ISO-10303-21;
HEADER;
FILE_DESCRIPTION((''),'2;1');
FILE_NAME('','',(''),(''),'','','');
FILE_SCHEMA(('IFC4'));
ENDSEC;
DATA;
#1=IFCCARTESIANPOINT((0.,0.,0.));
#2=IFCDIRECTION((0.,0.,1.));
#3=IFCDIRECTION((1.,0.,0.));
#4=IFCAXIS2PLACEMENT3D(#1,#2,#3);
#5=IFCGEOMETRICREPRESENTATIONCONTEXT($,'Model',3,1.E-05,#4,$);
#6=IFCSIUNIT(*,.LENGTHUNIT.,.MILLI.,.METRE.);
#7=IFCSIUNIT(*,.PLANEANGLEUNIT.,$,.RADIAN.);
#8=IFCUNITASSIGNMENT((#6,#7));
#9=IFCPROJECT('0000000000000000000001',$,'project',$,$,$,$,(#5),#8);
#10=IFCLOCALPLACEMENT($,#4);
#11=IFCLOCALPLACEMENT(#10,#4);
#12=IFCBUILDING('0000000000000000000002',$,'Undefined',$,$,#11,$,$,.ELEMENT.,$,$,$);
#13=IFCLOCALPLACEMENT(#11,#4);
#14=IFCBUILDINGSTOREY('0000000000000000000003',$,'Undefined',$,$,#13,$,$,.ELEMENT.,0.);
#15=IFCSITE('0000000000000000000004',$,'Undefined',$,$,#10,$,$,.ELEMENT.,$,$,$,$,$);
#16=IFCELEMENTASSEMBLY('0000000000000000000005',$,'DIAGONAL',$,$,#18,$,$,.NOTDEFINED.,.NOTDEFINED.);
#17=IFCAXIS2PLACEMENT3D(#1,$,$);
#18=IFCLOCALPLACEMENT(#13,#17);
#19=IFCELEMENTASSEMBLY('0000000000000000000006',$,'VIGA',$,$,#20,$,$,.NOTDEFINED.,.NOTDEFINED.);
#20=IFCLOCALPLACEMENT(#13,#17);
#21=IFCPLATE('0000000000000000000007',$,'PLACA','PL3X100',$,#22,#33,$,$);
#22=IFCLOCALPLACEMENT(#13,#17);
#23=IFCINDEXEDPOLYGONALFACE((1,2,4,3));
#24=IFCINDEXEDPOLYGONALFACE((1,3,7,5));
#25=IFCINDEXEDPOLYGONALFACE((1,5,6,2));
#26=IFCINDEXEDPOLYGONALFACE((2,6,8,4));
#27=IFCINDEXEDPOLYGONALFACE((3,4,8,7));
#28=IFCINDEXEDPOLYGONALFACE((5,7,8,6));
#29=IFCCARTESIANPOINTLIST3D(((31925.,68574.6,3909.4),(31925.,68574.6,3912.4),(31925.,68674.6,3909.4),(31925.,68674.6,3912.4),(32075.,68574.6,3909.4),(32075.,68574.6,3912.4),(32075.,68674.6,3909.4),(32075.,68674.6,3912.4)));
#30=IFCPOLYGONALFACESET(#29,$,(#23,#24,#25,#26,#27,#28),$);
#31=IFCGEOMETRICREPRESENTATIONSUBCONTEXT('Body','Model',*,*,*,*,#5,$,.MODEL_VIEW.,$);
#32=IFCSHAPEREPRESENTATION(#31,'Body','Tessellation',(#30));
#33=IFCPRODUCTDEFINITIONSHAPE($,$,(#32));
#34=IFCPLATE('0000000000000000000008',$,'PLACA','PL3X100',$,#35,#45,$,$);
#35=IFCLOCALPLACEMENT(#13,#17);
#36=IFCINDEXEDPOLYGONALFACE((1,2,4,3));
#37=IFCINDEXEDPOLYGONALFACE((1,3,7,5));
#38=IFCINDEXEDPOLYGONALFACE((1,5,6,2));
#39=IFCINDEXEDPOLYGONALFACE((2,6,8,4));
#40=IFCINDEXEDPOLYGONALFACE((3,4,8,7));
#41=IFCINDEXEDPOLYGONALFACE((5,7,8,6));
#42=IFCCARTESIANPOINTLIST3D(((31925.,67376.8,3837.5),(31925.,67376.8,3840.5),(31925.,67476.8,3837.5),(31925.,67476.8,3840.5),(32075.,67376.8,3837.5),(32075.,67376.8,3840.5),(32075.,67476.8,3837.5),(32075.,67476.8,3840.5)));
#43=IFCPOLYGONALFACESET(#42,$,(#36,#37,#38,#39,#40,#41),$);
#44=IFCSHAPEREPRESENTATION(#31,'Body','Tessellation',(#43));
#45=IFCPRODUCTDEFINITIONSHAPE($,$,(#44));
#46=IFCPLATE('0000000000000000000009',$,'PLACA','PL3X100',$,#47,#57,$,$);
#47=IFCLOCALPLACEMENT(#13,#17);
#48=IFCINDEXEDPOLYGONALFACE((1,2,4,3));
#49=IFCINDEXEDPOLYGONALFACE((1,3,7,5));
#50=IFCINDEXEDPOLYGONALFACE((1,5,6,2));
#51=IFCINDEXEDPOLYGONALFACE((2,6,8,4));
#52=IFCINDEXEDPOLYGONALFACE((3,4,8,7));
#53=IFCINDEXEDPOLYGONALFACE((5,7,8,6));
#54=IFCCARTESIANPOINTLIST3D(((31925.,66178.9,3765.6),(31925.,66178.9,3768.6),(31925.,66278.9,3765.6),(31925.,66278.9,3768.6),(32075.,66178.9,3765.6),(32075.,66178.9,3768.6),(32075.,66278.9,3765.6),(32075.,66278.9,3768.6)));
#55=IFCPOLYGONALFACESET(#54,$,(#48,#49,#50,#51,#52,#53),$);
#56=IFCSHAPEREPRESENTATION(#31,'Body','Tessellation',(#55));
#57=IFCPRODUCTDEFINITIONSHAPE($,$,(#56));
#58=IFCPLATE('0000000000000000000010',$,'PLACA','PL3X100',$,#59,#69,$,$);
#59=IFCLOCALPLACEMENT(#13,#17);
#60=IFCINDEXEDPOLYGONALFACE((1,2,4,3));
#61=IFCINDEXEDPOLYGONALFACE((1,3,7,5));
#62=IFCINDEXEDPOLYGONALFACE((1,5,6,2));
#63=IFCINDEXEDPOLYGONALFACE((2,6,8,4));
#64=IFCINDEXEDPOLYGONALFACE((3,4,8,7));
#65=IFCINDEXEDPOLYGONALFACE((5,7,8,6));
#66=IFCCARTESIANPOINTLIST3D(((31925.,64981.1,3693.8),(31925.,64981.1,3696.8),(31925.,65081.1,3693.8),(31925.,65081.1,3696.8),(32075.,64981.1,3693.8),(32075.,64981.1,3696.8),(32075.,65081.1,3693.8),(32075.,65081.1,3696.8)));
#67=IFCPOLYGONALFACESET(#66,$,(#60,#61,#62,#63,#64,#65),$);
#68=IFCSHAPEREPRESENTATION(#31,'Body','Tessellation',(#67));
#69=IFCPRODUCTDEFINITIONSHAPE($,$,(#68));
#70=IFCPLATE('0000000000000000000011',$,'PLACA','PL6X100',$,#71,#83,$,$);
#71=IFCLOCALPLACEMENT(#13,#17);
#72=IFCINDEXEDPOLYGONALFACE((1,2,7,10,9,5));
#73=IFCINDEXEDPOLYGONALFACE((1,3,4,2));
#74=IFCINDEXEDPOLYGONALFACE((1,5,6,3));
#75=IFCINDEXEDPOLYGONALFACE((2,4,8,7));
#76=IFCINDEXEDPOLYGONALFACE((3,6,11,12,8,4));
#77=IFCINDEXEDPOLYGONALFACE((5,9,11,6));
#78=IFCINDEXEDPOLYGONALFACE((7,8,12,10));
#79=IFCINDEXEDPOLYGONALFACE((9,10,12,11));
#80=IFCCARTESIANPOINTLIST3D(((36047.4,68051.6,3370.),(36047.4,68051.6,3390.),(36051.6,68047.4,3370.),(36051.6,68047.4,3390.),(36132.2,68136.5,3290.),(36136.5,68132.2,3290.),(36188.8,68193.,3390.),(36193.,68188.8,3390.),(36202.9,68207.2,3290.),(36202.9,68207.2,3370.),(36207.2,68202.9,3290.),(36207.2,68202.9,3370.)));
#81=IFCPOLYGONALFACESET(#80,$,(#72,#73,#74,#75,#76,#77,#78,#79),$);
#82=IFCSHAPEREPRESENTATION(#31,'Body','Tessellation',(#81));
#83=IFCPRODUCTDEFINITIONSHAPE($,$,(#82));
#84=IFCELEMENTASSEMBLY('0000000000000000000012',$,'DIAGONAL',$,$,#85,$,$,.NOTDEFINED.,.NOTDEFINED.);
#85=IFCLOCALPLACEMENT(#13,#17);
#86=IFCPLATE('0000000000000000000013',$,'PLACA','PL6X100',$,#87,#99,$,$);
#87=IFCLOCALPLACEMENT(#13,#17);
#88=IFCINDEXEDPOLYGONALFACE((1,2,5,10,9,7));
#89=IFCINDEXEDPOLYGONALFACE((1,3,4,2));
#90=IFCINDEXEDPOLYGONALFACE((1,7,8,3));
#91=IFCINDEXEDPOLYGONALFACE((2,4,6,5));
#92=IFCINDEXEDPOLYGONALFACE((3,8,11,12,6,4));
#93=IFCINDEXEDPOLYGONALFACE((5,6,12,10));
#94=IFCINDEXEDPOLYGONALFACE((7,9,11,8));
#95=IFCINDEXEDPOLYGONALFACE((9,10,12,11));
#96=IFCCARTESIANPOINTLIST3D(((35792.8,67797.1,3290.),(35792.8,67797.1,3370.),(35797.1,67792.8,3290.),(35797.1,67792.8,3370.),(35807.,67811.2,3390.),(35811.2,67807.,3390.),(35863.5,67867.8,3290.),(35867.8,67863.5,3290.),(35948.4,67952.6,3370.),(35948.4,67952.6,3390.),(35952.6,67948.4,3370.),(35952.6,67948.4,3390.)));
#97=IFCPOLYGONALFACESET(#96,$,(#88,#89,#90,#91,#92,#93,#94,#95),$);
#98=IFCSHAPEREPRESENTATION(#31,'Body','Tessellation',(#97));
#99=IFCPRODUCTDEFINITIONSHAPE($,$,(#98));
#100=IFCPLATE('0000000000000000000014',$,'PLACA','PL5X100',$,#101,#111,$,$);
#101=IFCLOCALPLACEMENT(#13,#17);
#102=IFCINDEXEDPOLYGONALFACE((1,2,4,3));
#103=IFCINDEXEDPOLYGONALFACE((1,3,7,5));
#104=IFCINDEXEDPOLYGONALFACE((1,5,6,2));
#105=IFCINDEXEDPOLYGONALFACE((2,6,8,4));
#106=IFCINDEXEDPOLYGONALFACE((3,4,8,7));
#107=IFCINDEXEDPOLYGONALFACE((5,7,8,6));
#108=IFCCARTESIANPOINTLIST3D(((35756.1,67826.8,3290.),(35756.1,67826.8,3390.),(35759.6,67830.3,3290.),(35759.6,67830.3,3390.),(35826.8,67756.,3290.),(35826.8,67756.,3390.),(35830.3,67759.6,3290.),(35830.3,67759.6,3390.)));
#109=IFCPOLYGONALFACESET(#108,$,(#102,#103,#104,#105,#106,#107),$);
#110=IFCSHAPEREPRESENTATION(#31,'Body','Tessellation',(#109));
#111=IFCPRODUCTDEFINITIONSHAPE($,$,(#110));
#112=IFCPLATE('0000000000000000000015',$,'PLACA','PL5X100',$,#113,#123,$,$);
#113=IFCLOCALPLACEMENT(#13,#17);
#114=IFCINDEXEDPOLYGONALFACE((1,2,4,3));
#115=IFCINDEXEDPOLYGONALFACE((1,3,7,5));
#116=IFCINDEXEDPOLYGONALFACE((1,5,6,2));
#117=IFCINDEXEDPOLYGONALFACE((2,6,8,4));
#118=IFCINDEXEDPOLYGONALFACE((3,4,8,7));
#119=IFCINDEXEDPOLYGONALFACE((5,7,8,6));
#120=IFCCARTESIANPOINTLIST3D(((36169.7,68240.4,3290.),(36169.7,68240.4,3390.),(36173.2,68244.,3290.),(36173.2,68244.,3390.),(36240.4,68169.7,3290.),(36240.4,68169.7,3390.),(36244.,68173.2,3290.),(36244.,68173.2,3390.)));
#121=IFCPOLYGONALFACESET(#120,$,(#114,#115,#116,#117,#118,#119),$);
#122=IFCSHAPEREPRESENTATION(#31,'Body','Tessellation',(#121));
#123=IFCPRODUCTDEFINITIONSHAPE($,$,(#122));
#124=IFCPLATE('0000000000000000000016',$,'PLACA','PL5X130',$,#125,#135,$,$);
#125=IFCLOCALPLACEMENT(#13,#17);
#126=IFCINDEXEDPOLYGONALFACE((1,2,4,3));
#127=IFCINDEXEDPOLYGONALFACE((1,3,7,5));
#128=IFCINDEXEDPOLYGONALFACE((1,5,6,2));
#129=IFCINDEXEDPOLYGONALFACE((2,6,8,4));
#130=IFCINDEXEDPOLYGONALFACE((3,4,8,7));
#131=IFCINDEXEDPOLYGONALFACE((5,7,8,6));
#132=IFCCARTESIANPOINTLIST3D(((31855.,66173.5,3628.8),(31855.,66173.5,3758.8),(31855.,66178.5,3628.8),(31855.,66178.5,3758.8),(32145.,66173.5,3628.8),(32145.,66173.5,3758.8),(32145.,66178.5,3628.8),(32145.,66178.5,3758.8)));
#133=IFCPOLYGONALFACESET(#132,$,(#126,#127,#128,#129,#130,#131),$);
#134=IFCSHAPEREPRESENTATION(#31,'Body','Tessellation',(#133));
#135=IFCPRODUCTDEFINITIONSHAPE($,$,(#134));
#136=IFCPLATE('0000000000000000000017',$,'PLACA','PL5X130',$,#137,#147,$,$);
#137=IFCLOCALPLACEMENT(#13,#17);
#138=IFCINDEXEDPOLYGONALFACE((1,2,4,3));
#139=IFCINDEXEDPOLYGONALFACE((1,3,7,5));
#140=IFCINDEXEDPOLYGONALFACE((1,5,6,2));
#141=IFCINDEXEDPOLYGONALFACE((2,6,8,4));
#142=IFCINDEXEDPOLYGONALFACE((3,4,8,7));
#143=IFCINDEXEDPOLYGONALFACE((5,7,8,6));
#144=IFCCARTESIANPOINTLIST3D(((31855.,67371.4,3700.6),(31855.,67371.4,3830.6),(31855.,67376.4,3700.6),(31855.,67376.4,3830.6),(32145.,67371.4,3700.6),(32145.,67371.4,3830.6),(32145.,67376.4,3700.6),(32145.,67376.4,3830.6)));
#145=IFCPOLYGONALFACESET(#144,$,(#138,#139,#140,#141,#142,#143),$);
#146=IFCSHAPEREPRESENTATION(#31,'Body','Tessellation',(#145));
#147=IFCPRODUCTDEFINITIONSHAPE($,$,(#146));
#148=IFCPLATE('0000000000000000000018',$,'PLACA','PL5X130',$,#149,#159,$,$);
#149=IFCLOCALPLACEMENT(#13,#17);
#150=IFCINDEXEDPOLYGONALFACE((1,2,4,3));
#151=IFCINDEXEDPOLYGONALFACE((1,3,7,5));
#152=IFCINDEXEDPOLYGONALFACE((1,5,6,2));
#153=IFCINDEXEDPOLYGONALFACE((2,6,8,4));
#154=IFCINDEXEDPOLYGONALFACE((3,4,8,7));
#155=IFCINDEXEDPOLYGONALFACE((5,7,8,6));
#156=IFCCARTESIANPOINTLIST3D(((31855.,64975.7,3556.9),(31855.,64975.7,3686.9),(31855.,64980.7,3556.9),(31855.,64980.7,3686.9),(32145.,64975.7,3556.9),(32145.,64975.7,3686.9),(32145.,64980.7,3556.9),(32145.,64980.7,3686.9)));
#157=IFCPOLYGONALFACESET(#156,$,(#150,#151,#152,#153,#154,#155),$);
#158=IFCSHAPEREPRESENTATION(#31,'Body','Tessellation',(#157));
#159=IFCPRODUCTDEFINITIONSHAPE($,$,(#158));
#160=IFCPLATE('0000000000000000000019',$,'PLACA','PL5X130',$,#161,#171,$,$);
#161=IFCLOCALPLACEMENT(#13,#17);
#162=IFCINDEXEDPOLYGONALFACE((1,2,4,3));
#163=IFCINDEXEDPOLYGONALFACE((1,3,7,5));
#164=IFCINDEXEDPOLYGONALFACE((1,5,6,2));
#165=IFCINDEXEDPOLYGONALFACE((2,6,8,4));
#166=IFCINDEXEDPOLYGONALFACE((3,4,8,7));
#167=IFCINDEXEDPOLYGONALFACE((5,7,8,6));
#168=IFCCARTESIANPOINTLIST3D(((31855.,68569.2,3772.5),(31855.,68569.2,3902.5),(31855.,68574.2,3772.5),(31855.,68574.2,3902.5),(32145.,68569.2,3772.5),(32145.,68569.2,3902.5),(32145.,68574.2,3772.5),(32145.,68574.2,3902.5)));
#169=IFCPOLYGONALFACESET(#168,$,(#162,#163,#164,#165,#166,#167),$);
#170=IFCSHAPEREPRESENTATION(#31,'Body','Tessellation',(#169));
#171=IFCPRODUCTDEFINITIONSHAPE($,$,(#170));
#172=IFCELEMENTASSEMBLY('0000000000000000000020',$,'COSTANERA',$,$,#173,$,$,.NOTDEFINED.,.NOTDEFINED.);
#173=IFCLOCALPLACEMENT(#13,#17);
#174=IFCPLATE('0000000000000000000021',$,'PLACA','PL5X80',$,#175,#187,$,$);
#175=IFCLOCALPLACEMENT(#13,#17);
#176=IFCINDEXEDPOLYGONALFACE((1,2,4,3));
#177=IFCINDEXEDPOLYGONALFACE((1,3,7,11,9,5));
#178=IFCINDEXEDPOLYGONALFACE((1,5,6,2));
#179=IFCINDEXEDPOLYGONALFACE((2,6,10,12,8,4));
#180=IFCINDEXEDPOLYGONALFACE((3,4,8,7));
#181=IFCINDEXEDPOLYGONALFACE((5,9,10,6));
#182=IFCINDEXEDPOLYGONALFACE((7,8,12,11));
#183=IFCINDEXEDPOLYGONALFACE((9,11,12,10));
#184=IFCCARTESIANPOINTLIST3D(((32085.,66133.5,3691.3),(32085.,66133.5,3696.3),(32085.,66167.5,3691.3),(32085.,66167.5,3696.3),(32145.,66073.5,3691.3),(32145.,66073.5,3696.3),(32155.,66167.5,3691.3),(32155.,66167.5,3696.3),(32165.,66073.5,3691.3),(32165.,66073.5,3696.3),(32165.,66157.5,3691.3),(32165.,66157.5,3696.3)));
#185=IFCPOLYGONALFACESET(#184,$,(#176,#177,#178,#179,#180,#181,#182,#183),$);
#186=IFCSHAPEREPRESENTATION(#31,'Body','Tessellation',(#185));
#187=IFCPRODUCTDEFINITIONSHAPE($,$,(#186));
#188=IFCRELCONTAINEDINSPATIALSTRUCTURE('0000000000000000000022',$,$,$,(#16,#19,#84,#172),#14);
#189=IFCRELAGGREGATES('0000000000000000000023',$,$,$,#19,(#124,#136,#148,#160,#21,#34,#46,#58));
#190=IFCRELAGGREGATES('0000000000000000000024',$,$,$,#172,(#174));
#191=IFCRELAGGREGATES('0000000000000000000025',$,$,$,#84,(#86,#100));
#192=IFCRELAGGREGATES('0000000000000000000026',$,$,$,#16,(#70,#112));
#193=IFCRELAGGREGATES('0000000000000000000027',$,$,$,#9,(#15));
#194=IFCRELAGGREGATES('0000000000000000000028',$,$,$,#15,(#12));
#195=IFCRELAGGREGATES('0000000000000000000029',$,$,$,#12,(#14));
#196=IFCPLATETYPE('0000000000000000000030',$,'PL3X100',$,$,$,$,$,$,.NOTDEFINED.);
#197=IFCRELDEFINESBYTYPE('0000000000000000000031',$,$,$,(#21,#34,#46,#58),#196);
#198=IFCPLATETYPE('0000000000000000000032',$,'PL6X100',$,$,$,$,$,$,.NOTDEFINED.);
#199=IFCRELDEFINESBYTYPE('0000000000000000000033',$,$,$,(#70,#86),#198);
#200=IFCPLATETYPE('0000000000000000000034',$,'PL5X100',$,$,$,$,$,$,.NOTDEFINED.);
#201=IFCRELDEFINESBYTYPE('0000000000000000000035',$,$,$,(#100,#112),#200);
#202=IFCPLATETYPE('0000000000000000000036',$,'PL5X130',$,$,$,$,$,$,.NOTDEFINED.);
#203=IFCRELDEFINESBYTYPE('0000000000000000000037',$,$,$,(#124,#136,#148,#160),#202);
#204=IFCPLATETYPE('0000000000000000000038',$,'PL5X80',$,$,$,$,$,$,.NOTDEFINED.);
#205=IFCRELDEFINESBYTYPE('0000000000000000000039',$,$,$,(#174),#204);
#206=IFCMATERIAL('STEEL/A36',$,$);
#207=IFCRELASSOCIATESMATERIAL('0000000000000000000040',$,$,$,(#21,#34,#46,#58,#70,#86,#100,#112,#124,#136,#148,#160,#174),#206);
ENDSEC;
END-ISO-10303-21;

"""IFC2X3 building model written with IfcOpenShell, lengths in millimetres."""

from ifc_helpers import new_model, si_unit, frame, origin_with_axes, place, context, subcontext, project, spatial, polyline, outline, extrude, material, type_object, element, aggregate, save


model = new_model("IFC2X3")

# Units and contexts
model_context = context("Model", 3, precision=1e-05, world=origin_with_axes())
body_context = subcontext(model_context, "Body", "Model", "MODEL_VIEW")
ifc_project = project(units=[si_unit("LENGTHUNIT", "METRE", prefix="MILLI"), si_unit("PLANEANGLEUNIT", "RADIAN")], contexts=[model_context])

# Site, building, storey
site_placement = place(None, origin_with_axes())
site = spatial("IfcSite", under=ifc_project, at=site_placement, Name="Undefined", CompositionType="ELEMENT")
building_placement = place(site_placement, origin_with_axes())
building = spatial("IfcBuilding", under=site, at=building_placement, Name="Undefined", CompositionType="ELEMENT")
storey_placement = place(building_placement, origin_with_axes())
storey = spatial("IfcBuildingStorey", under=building, at=storey_placement, Name="Undefined", CompositionType="ELEMENT", Elevation=0.0)

# Element assembly
assembly_1_placement = place(storey_placement, origin_with_axes())
assembly_1 = element("IfcElementAssembly", 1, at=assembly_1_placement, inside=storey, Name="DIAGONAL", AssemblyPlace="NOTDEFINED", PredefinedType="NOTDEFINED")
ifc_material_1 = material(Name="STEEL/A36")

# Element assembly, plates
assembly_2_placement = place(storey_placement, origin_with_axes())
assembly_2 = element("IfcElementAssembly", 2, at=assembly_2_placement, inside=storey, Name="VIGA", AssemblyPlace="NOTDEFINED", PredefinedType="NOTDEFINED")
plate_type_1 = type_object("IfcPlateType", Name="PL3X100", PredefinedType="NOTDEFINED")
plate_1_placement = place(assembly_2_placement, frame((32075.0, 68674.6, 3910.9), z_axis=(0.0, 0.0, -1.0), x_axis=(0.0, -1.0, 0.0)))
plate_1 = element("IfcPlate", 3, at=plate_1_placement, type_object=plate_type_1, material=ifc_material_1, Name="PLACA", Description="PL3X100", context=body_context, shape_type="SweptSolid", body=[
    extrude(outline(polyline([(0.0, 0.0), (100.0, 0.0), (100.0, 150.0), (0.0, 150.0), (0.0, 0.0)])), frame((0.0, 0.0, -1.5), z_axis=(0.0, 0.0, 1.0), x_axis=(1.0, 0.0, 0.0)), (0.0, 0.0, 1.0), 3.0),
])
plate_2_placement = place(assembly_2_placement, frame((32075.0, 67476.8, 3839.0), z_axis=(0.0, 0.0, -1.0), x_axis=(0.0, -1.0, 0.0)))
plate_2 = element("IfcPlate", 4, at=plate_2_placement, type_object=plate_type_1, material=ifc_material_1, Name="PLACA", Description="PL3X100", context=body_context, shape_type="SweptSolid", body=[
    extrude(outline(polyline([(0.0, 0.0), (100.0, 0.0), (100.0, 150.0), (0.0, 150.0), (0.0, 0.0)])), frame((0.0, 0.0, -1.5), z_axis=(0.0, 0.0, 1.0), x_axis=(1.0, 0.0, 0.0)), (0.0, 0.0, 1.0), 3.0),
])
plate_3_placement = place(assembly_2_placement, frame((32075.0, 66278.9, 3767.1), z_axis=(0.0, 0.0, -1.0), x_axis=(0.0, -1.0, 0.0)))
plate_3 = element("IfcPlate", 5, at=plate_3_placement, type_object=plate_type_1, material=ifc_material_1, Name="PLACA", Description="PL3X100", context=body_context, shape_type="SweptSolid", body=[
    extrude(outline(polyline([(0.0, 0.0), (100.0, 0.0), (100.0, 150.0), (0.0, 150.0), (0.0, 0.0)])), frame((0.0, 0.0, -1.5), z_axis=(0.0, 0.0, 1.0), x_axis=(1.0, 0.0, 0.0)), (0.0, 0.0, 1.0), 3.0),
])
plate_4_placement = place(assembly_2_placement, frame((32075.0, 65081.1, 3695.3), z_axis=(0.0, 0.0, -1.0), x_axis=(0.0, -1.0, 0.0)))
plate_4 = element("IfcPlate", 6, at=plate_4_placement, type_object=plate_type_1, material=ifc_material_1, Name="PLACA", Description="PL3X100", context=body_context, shape_type="SweptSolid", body=[
    extrude(outline(polyline([(0.0, 0.0), (100.0, 0.0), (100.0, 150.0), (0.0, 150.0), (0.0, 0.0)])), frame((0.0, 0.0, -1.5), z_axis=(0.0, 0.0, 1.0), x_axis=(1.0, 0.0, 0.0)), (0.0, 0.0, 1.0), 3.0),
])

# Plate
plate_type_2 = type_object("IfcPlateType", Name="PL6X100", PredefinedType="NOTDEFINED")
plate_5_placement = place(assembly_1_placement, frame((36049.5, 68049.5, 3290.0), z_axis=(0.707107, -0.707107, 0.0), x_axis=(0.707107, 0.707107, 0.0)))
plate_5 = element("IfcPlate", 7, at=plate_5_placement, type_object=plate_type_2, material=ifc_material_1, Name="PLACA", Description="PL6X100", context=body_context, shape_type="SweptSolid", body=[
    extrude(outline(polyline([(0.0, 80.0), (120.0, 0.0), (220.0, 0.0), (220.0, 80.0), (200.0, 100.0), (0.0, 100.0), (0.0, 80.0)])), frame((0.0, 0.0, -3.0), z_axis=(0.0, 0.0, 1.0), x_axis=(1.0, 0.0, 0.0)), (0.0, 0.0, 1.0), 6.0),
])

# Element assembly, plates
assembly_3_placement = place(storey_placement, origin_with_axes())
assembly_3 = element("IfcElementAssembly", 8, at=assembly_3_placement, inside=storey, Name="DIAGONAL", AssemblyPlace="NOTDEFINED", PredefinedType="NOTDEFINED")
plate_6_placement = place(assembly_3_placement, frame((35950.5, 67950.5, 3290.0), z_axis=(-0.707107, 0.707107, 0.0), x_axis=(-0.707107, -0.707107, 0.0)))
plate_6 = element("IfcPlate", 9, at=plate_6_placement, type_object=plate_type_2, material=ifc_material_1, Name="PLACA", Description="PL6X100", context=body_context, shape_type="SweptSolid", body=[
    extrude(outline(polyline([(0.0, 80.0), (120.0, 0.0), (220.0, 0.0), (220.0, 80.0), (200.0, 100.0), (0.0, 100.0), (0.0, 80.0)])), frame((0.0, 0.0, -3.0), z_axis=(0.0, 0.0, 1.0), x_axis=(1.0, 0.0, 0.0)), (0.0, 0.0, 1.0), 6.0),
])
plate_type_3 = type_object("IfcPlateType", Name="PL5X100", PredefinedType="NOTDEFINED")
plate_7_placement = place(assembly_3_placement, frame((35793.2, 67793.2, 3390.0), z_axis=(-0.707107, -0.707107, 0.0), x_axis=(0.0, 0.0, -1.0)))
plate_7 = element("IfcPlate", 10, at=plate_7_placement, type_object=plate_type_3, material=ifc_material_1, Name="PLACA", Description="PL5X100", context=body_context, shape_type="SweptSolid", body=[
    extrude(outline(polyline([(0.0, -50.0), (0.0, 50.0), (100.0, 50.0), (100.0, -50.0), (0.0, -50.0)])), frame((0.0, 0.0, -2.5), z_axis=(0.0, 0.0, 1.0), x_axis=(1.0, 0.0, 0.0)), (0.0, 0.0, 1.0), 5.0),
])

# Plates
plate_8_placement = place(assembly_1_placement, frame((36206.8, 68206.8, 3390.0), z_axis=(0.707107, 0.707107, 0.0), x_axis=(0.0, 0.0, -1.0)))
plate_8 = element("IfcPlate", 11, at=plate_8_placement, type_object=plate_type_3, material=ifc_material_1, Name="PLACA", Description="PL5X100", context=body_context, shape_type="SweptSolid", body=[
    extrude(outline(polyline([(0.0, -50.0), (0.0, 50.0), (100.0, 50.0), (100.0, -50.0), (0.0, -50.0)])), frame((0.0, 0.0, -2.5), z_axis=(0.0, 0.0, 1.0), x_axis=(1.0, 0.0, 0.0)), (0.0, 0.0, 1.0), 5.0),
])
plate_type_4 = type_object("IfcPlateType", Name="PL5X130", PredefinedType="NOTDEFINED")
plate_9_placement = place(assembly_2_placement, frame((32145.0, 66176.0, 3758.8), z_axis=(0.0, -1.0, 0.0), x_axis=(-1.0, 0.0, 0.0)))
plate_9 = element("IfcPlate", 12, at=plate_9_placement, type_object=plate_type_4, material=ifc_material_1, Name="PLACA", Description="PL5X130", context=body_context, shape_type="SweptSolid", body=[
    extrude(outline(polyline([(0.0, 0.0), (290.0, 0.0), (290.0, 130.0), (0.0, 130.0), (0.0, 0.0)])), frame((0.0, 0.0, -2.5), z_axis=(0.0, 0.0, 1.0), x_axis=(1.0, 0.0, 0.0)), (0.0, 0.0, 1.0), 5.0),
])
plate_10_placement = place(assembly_2_placement, frame((32145.0, 67373.9, 3830.6), z_axis=(0.0, -1.0, 0.0), x_axis=(-1.0, 0.0, 0.0)))
plate_10 = element("IfcPlate", 13, at=plate_10_placement, type_object=plate_type_4, material=ifc_material_1, Name="PLACA", Description="PL5X130", context=body_context, shape_type="SweptSolid", body=[
    extrude(outline(polyline([(0.0, 0.0), (290.0, 0.0), (290.0, 130.0), (0.0, 130.0), (0.0, 0.0)])), frame((0.0, 0.0, -2.5), z_axis=(0.0, 0.0, 1.0), x_axis=(1.0, 0.0, 0.0)), (0.0, 0.0, 1.0), 5.0),
])
plate_11_placement = place(assembly_2_placement, frame((32145.0, 64978.2, 3686.9), z_axis=(0.0, -1.0, 0.0), x_axis=(-1.0, 0.0, 0.0)))
plate_11 = element("IfcPlate", 14, at=plate_11_placement, type_object=plate_type_4, material=ifc_material_1, Name="PLACA", Description="PL5X130", context=body_context, shape_type="SweptSolid", body=[
    extrude(outline(polyline([(0.0, 0.0), (290.0, 0.0), (290.0, 130.0), (0.0, 130.0), (0.0, 0.0)])), frame((0.0, 0.0, -2.5), z_axis=(0.0, 0.0, 1.0), x_axis=(1.0, 0.0, 0.0)), (0.0, 0.0, 1.0), 5.0),
])
plate_12_placement = place(assembly_2_placement, frame((32145.0, 68571.7, 3902.5), z_axis=(0.0, -1.0, 0.0), x_axis=(-1.0, 0.0, 0.0)))
plate_12 = element("IfcPlate", 15, at=plate_12_placement, type_object=plate_type_4, material=ifc_material_1, Name="PLACA", Description="PL5X130", context=body_context, shape_type="SweptSolid", body=[
    extrude(outline(polyline([(0.0, 0.0), (290.0, 0.0), (290.0, 130.0), (0.0, 130.0), (0.0, 0.0)])), frame((0.0, 0.0, -2.5), z_axis=(0.0, 0.0, 1.0), x_axis=(1.0, 0.0, 0.0)), (0.0, 0.0, 1.0), 5.0),
])
aggregate(assembly_2, [plate_9, plate_10, plate_11, plate_12, plate_1, plate_2, plate_3, plate_4])

# Element assembly, plate
assembly_4_placement = place(storey_placement, origin_with_axes())
assembly_4 = element("IfcElementAssembly", 16, at=assembly_4_placement, inside=storey, Name="COSTANERA", AssemblyPlace="NOTDEFINED", PredefinedType="NOTDEFINED")
plate_type_5 = type_object("IfcPlateType", Name="PL5X80", PredefinedType="NOTDEFINED")
plate_13_placement = place(assembly_4_placement, frame((32085.0, 66167.5, 3693.8), z_axis=(0.0, 0.0, -1.0), x_axis=(1.0, 0.0, 0.0)))
plate_13 = element("IfcPlate", 17, at=plate_13_placement, type_object=plate_type_5, material=ifc_material_1, Name="PLACA", Description="PL5X80", context=body_context, shape_type="SweptSolid", body=[
    extrude(outline(polyline([(0.0, 0.0), (70.0, 0.0), (80.0, 10.0), (80.0, 94.0), (60.0, 94.0), (0.0, 34.0), (0.0, 0.0)])), frame((0.0, 0.0, -2.5), z_axis=(0.0, 0.0, 1.0), x_axis=(1.0, 0.0, 0.0)), (0.0, 0.0, 1.0), 5.0),
])

aggregate(assembly_4, [plate_13])
aggregate(assembly_3, [plate_6, plate_7])
aggregate(assembly_1, [plate_5, plate_8])

save(model, "model.ifc")
